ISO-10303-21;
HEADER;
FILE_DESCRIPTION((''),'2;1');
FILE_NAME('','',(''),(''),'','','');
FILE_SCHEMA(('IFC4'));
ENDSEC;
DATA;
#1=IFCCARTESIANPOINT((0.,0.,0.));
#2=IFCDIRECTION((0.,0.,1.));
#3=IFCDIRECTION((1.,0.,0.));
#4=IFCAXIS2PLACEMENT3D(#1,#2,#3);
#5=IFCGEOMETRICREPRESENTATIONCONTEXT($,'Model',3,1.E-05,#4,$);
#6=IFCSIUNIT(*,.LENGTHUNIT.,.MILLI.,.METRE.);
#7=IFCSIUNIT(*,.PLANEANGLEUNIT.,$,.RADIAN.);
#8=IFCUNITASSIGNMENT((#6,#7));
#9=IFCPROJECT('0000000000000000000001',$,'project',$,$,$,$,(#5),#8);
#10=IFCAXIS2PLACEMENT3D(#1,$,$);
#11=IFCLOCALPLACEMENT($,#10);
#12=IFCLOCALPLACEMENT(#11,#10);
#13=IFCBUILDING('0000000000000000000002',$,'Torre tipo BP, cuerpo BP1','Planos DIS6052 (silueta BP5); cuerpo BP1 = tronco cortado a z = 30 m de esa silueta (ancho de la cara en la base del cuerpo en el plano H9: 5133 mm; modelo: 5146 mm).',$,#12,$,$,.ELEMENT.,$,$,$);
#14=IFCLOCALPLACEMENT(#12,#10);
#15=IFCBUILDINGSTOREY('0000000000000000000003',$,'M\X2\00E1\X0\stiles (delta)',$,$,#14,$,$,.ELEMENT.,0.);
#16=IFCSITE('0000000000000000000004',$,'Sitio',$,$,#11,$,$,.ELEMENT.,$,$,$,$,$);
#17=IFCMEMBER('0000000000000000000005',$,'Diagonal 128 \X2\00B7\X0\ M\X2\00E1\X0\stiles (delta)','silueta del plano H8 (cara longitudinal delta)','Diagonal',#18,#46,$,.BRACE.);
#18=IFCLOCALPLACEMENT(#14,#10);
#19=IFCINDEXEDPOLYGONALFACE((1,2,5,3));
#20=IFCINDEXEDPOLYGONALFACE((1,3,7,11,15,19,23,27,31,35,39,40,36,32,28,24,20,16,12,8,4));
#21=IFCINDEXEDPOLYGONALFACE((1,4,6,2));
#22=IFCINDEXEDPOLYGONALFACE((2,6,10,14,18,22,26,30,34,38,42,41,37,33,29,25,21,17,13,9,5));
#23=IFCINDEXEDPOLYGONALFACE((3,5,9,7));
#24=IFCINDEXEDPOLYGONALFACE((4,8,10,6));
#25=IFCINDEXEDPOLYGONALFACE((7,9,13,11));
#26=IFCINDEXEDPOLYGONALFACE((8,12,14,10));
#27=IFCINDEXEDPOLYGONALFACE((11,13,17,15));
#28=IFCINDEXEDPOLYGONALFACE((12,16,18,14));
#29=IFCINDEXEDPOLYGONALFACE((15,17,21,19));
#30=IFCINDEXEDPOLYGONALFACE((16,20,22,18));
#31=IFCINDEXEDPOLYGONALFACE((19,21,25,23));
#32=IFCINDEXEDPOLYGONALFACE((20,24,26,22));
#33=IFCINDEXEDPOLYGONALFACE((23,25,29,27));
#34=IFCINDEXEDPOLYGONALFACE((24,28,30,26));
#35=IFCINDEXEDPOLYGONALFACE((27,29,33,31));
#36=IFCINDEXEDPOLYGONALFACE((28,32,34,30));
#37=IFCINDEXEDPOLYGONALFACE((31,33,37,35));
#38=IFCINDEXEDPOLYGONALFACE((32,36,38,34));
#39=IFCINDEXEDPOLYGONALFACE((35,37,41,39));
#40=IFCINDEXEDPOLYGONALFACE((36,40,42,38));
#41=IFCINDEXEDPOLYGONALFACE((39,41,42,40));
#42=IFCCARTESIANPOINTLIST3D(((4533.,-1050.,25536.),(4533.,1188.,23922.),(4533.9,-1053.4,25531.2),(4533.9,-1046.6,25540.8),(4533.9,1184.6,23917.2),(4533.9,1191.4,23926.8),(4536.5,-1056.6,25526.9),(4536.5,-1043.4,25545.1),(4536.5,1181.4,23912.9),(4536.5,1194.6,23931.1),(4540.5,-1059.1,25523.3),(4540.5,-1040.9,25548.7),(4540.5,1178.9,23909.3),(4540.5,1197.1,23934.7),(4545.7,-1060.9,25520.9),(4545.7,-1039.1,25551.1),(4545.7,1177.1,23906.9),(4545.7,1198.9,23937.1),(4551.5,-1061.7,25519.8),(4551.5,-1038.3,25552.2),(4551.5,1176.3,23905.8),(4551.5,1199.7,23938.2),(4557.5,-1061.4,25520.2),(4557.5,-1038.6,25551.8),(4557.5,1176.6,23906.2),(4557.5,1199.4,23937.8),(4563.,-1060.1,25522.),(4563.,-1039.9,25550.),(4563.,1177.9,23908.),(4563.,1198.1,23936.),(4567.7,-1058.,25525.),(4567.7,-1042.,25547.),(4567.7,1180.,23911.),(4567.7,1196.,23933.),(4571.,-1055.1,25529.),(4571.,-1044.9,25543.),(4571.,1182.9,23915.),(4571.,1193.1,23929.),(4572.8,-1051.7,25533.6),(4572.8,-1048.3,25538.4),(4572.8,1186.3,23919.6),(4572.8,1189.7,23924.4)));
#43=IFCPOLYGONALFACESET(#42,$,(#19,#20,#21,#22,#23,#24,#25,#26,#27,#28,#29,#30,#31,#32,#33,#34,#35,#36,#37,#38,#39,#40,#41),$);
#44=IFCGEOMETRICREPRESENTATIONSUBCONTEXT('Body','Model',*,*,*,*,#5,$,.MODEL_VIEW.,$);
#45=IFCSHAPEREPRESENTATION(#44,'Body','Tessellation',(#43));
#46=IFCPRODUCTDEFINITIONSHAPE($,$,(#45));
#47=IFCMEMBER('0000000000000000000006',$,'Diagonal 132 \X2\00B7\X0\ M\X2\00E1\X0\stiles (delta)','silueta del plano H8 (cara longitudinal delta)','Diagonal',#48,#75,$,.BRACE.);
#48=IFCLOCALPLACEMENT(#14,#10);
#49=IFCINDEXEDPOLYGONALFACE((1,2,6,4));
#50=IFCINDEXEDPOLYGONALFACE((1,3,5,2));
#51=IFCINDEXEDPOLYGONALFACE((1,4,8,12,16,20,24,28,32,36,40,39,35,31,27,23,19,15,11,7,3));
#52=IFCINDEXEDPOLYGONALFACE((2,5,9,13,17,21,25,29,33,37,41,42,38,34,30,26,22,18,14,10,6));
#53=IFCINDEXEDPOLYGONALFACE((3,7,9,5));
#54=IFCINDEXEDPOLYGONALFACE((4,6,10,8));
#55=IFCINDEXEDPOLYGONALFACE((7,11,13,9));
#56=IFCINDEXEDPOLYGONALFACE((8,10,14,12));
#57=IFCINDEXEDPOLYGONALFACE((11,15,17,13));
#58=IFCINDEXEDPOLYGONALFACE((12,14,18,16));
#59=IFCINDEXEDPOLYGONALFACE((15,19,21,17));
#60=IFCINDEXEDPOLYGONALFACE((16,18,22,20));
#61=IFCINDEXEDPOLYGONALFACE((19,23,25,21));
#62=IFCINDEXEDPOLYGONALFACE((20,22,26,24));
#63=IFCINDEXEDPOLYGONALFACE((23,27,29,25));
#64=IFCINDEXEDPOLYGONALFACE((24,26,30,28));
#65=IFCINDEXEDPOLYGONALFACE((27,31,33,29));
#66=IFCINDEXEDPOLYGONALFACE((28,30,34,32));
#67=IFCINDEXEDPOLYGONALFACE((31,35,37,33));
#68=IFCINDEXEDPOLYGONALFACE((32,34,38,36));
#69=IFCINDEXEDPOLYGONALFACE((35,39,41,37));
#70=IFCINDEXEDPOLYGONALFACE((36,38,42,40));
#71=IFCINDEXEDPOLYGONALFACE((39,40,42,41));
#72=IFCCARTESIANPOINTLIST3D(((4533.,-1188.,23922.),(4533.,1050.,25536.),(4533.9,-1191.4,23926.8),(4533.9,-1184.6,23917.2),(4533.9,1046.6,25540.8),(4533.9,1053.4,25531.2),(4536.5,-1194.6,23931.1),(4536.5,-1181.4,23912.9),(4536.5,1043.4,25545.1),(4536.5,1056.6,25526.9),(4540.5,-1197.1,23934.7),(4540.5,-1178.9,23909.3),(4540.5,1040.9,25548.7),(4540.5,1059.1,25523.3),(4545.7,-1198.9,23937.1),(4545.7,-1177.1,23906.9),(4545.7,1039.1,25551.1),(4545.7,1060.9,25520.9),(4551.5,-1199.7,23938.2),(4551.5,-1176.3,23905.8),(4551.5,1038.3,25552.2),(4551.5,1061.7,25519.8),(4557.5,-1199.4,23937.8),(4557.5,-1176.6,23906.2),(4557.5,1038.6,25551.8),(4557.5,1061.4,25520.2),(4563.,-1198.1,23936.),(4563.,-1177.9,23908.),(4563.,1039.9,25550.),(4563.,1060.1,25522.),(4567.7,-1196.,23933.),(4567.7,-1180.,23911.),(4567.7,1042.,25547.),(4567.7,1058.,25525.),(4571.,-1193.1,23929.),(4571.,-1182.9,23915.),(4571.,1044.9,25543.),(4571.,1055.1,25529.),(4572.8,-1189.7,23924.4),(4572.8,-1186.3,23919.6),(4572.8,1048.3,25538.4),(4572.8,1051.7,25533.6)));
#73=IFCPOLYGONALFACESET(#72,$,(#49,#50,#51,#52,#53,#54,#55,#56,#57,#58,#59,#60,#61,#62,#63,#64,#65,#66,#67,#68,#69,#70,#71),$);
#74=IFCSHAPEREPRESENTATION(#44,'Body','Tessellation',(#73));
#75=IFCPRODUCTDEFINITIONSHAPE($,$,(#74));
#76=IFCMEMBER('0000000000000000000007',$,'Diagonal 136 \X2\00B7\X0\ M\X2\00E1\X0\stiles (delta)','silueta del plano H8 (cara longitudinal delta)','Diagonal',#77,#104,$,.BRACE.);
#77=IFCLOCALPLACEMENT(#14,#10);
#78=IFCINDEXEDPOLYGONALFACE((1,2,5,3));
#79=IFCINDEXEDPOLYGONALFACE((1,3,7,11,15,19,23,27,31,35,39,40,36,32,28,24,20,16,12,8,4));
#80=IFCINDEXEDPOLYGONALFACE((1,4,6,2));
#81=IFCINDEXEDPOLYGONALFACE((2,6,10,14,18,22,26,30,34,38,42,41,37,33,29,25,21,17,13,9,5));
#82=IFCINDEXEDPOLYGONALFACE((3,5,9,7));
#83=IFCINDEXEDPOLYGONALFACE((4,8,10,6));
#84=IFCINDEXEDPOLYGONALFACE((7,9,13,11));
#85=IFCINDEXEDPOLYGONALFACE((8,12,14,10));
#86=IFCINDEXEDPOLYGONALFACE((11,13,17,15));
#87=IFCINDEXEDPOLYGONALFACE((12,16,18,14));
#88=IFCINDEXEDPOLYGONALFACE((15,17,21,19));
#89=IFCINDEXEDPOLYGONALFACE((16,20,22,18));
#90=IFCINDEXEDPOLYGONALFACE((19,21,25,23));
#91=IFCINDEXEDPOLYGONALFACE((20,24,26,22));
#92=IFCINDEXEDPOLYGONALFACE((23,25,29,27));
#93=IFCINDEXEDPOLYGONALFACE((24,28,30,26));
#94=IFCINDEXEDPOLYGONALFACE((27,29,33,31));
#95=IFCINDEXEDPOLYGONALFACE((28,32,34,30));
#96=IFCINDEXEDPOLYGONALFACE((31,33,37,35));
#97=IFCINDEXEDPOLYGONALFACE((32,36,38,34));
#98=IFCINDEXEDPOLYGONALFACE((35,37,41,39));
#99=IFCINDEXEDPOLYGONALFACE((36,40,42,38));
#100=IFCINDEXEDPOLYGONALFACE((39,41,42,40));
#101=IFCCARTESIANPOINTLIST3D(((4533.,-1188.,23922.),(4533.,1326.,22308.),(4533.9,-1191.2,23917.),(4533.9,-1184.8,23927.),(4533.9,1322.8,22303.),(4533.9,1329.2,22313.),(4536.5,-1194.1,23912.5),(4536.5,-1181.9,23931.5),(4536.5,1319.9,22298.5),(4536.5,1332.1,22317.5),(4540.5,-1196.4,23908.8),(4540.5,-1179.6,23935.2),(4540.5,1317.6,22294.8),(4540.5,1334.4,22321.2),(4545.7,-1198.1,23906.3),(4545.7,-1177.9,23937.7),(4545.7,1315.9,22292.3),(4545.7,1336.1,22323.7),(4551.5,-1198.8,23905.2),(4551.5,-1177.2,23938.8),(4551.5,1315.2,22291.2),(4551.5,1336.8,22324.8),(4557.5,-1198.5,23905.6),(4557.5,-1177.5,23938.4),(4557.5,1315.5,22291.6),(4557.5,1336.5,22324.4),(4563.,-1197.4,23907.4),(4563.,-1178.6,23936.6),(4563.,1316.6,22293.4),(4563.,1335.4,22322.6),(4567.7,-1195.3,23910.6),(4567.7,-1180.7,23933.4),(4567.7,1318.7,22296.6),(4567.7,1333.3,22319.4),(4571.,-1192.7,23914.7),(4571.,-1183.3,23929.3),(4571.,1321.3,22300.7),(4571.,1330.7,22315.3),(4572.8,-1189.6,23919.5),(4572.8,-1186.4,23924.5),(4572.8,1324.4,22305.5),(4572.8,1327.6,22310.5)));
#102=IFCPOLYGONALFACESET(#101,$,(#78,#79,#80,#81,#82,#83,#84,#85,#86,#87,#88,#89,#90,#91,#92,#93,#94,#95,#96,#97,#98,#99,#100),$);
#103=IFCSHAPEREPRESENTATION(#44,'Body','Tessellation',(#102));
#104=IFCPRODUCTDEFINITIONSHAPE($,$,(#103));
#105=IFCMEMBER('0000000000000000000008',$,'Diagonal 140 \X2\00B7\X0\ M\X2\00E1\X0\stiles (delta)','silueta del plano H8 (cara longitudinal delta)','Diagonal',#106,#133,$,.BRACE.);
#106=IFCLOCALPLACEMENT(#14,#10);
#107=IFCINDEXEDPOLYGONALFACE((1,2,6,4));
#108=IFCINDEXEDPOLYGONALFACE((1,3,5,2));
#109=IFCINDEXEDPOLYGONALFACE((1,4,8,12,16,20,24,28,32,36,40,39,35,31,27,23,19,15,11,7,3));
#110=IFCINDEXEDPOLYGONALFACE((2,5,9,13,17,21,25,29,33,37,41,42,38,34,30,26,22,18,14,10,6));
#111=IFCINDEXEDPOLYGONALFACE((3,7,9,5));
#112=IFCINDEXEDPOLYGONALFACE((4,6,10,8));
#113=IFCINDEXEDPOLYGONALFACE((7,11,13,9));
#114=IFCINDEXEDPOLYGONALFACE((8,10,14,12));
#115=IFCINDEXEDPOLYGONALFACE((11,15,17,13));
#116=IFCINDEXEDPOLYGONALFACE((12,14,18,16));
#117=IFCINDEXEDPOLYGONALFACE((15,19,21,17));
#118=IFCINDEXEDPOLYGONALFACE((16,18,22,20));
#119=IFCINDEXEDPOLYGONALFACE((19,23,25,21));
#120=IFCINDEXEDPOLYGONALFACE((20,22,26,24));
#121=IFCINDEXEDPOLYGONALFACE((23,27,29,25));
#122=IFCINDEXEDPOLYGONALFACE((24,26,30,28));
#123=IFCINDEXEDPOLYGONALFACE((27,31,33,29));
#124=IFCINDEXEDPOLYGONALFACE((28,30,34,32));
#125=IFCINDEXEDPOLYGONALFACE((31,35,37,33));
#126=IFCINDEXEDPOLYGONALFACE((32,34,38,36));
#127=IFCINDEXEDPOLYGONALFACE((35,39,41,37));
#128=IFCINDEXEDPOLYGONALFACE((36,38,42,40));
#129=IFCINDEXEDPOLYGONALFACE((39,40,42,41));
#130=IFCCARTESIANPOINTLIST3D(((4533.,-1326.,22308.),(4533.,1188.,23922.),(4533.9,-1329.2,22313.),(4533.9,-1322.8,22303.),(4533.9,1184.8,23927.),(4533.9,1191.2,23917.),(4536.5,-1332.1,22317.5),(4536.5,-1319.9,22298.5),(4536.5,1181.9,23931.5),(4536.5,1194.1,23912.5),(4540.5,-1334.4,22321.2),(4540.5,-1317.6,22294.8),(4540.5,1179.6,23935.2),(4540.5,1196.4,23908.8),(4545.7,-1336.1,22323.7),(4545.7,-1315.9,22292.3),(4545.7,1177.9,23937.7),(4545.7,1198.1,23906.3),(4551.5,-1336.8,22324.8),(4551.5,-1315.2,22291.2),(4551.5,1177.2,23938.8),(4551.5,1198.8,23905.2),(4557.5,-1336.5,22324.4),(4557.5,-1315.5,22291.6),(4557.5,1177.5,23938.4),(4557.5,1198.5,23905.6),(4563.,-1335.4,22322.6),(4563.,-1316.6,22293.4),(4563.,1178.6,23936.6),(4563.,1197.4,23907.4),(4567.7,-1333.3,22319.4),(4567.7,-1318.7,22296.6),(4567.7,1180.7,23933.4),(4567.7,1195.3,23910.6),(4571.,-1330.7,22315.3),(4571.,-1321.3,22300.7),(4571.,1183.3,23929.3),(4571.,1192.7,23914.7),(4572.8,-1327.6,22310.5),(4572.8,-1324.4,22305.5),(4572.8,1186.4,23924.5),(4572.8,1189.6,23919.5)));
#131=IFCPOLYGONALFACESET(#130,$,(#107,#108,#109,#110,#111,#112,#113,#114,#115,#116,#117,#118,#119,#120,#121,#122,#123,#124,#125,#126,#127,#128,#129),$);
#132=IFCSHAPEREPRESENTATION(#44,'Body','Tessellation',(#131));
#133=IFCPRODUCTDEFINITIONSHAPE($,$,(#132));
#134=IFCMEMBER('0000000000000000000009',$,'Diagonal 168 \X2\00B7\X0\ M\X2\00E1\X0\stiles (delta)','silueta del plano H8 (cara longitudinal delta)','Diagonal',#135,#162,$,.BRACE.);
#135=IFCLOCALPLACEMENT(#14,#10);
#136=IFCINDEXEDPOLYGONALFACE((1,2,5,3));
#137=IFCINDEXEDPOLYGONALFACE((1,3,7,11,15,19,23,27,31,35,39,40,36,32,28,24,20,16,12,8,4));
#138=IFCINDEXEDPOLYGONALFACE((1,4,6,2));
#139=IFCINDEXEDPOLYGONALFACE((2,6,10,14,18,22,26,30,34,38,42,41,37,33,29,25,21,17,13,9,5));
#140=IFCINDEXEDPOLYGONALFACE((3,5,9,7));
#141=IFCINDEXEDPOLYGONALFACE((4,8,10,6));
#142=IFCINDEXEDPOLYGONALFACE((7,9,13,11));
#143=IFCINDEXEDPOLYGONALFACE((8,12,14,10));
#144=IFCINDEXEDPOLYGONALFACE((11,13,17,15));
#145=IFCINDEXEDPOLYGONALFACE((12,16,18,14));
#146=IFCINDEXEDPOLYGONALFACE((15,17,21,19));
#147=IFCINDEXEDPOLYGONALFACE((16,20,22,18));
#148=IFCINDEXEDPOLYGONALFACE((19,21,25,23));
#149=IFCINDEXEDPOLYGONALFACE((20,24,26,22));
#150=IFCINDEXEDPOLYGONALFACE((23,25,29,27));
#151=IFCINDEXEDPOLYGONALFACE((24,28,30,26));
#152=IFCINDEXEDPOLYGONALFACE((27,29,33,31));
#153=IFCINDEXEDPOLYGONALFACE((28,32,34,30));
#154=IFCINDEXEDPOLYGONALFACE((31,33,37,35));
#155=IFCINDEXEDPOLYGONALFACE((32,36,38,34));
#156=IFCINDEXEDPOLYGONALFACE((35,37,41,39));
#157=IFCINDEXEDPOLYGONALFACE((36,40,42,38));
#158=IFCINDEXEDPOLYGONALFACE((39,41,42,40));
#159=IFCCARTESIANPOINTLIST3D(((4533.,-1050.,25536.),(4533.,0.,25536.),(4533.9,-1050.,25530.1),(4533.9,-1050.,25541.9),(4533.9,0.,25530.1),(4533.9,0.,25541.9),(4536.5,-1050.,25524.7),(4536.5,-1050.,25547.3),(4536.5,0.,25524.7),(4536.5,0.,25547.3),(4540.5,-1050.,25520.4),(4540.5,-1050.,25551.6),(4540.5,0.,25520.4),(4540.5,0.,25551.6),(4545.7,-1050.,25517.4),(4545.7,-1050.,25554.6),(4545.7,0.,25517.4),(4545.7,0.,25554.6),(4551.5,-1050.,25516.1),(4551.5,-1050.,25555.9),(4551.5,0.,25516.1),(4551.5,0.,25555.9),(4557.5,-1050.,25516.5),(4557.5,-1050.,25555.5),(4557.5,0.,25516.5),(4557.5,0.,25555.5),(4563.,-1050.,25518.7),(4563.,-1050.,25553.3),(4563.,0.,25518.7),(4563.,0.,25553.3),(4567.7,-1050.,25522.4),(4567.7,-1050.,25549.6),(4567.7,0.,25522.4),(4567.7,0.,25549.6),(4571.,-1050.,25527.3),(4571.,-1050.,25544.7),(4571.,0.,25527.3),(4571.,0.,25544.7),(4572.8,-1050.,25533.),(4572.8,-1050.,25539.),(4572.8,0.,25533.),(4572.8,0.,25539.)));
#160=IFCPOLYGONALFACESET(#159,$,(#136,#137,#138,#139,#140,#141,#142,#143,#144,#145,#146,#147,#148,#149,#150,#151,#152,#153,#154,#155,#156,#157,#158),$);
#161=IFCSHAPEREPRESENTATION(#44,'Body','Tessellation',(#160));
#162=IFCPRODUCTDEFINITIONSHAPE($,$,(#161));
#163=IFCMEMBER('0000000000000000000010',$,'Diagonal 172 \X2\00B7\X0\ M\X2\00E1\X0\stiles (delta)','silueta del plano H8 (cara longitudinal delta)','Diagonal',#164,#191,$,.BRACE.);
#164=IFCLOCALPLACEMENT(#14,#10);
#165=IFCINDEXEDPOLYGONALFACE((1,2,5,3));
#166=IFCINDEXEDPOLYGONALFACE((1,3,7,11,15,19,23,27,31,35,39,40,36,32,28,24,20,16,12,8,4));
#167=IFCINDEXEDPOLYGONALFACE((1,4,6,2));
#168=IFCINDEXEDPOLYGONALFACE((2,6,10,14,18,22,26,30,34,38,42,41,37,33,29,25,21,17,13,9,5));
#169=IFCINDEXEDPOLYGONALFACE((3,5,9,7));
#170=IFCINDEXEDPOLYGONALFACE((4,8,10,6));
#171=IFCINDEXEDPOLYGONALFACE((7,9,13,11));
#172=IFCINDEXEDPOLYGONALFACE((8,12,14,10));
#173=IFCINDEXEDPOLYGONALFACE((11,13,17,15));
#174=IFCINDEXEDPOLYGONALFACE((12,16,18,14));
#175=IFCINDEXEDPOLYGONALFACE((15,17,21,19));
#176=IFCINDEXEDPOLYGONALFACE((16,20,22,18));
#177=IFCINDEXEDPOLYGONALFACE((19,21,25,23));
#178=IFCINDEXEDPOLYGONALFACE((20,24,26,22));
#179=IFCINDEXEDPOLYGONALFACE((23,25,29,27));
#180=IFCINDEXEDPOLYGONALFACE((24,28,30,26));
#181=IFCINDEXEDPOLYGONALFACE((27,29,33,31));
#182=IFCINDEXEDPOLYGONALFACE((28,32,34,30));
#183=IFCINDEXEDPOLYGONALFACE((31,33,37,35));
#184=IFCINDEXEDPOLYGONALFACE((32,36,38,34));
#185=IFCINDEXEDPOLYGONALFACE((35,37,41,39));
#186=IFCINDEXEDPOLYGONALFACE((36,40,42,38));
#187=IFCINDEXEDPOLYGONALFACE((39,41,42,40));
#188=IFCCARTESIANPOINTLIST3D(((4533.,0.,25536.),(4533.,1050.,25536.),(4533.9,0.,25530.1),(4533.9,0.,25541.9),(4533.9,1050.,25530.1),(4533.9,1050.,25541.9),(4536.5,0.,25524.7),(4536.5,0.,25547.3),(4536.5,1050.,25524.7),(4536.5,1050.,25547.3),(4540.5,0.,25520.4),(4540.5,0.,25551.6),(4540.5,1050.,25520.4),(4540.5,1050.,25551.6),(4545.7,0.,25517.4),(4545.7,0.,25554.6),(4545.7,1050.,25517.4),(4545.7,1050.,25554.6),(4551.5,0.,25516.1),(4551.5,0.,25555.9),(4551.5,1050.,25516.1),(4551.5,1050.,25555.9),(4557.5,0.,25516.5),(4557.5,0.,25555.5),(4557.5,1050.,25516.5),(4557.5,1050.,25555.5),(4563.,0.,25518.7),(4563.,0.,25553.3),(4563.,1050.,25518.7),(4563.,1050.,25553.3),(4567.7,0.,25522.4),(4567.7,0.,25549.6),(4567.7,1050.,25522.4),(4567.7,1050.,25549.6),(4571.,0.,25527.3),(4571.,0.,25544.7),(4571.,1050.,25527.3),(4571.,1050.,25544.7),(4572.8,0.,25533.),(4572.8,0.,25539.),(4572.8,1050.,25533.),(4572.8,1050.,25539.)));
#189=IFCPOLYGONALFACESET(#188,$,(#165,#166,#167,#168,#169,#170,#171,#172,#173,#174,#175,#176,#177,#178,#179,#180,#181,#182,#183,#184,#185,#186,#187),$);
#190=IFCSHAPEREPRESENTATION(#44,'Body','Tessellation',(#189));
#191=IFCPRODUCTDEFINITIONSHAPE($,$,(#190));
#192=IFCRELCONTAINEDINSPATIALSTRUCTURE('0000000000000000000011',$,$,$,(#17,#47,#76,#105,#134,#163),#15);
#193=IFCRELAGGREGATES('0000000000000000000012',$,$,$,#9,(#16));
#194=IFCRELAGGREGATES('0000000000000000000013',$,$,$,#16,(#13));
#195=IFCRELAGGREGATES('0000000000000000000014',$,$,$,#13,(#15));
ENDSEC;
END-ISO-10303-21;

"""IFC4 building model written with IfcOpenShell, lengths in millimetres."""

from ifc_helpers import new_model, si_unit, frame, origin, origin_with_axes, place, context, subcontext, project, spatial, circle, extrude, element, save


model = new_model("IFC4")

# Units and contexts
model_context = context("Model", 3, precision=1e-05, world=origin_with_axes())
body_context = subcontext(model_context, "Body", "Model", "MODEL_VIEW")
ifc_project = project(units=[si_unit("LENGTHUNIT", "METRE", prefix="MILLI"), si_unit("PLANEANGLEUNIT", "RADIAN")], contexts=[model_context])

# Site, building, storey
site_placement = place(None, origin())
site = spatial("IfcSite", under=ifc_project, at=site_placement, Name="Sitio", CompositionType="ELEMENT")
building_placement = place(site_placement, origin())
building = spatial("IfcBuilding", under=site, at=building_placement, Name="Torre tipo BP, cuerpo BP1", Description="Planos DIS6052 (silueta BP5); cuerpo BP1 = tronco cortado a z = 30 m de esa silueta (ancho de la cara en la base del cuerpo en el plano H9: 5133 mm; modelo: 5146 mm).", CompositionType="ELEMENT")
storey_placement = place(building_placement, origin())
storey = spatial("IfcBuildingStorey", under=building, at=storey_placement, Name="Mástiles (delta)", CompositionType="ELEMENT", Elevation=0.0)

# Members
for number, where, z_axis, x_axis, name in (
    (1, (4553.0, -1050.0, 25536.0), (0.0, 0.81108, -0.584935), (-1.0, 0.0, 0.0), "Diagonal 128 · Mástiles (delta)"),
    (2, (4553.0, 1050.0, 25536.0), (0.0, -0.81108, -0.584935), (-1.0, 0.0, 0.0), "Diagonal 132 · Mástiles (delta)"),
):
    element("IfcMember", number, at=place(storey_placement, frame(where, z_axis=z_axis, x_axis=x_axis)), inside=storey, Name=name, Description="silueta del plano H8 (cara longitudinal delta)", ObjectType="Diagonal", PredefinedType="BRACE", context=body_context, shape_type="SweptSolid", body=[
        extrude(circle(Radius=20.0), None, (0.0, 0.0, 1.0), 2759.3),
    ])
for number, where, z_axis, x_axis, name in (
    (3, (4553.0, -1188.0, 23922.0), (0.0, 0.841505, -0.54025), (-1.0, 0.0, 0.0), "Diagonal 136 · Mástiles (delta)"),
    (4, (4553.0, 1188.0, 23922.0), (0.0, -0.841505, -0.54025), (-1.0, 0.0, 0.0), "Diagonal 140 · Mástiles (delta)"),
):
    element("IfcMember", number, at=place(storey_placement, frame(where, z_axis=z_axis, x_axis=x_axis)), inside=storey, Name=name, Description="silueta del plano H8 (cara longitudinal delta)", ObjectType="Diagonal", PredefinedType="BRACE", context=body_context, shape_type="SweptSolid", body=[
        extrude(circle(Radius=20.0), None, (0.0, 0.0, 1.0), 2987.5),
    ])
for number, where, z_axis, x_axis, name in (
    (5, (4553.0, -1050.0, 25536.0), (0.0, 1.0, 0.0), (-1.0, 0.0, 0.0), "Diagonal 168 · Mástiles (delta)"),
    (6, (4553.0, 1050.0, 25536.0), (0.0, -1.0, 0.0), (-1.0, 0.0, 0.0), "Diagonal 172 · Mástiles (delta)"),
):
    element("IfcMember", number, at=place(storey_placement, frame(where, z_axis=z_axis, x_axis=x_axis)), inside=storey, Name=name, Description="silueta del plano H8 (cara longitudinal delta)", ObjectType="Diagonal", PredefinedType="BRACE", context=body_context, shape_type="SweptSolid", body=[
        extrude(circle(Radius=20.0), None, (0.0, 0.0, 1.0), 1050.0),
    ])

save(model, "model.ifc")
